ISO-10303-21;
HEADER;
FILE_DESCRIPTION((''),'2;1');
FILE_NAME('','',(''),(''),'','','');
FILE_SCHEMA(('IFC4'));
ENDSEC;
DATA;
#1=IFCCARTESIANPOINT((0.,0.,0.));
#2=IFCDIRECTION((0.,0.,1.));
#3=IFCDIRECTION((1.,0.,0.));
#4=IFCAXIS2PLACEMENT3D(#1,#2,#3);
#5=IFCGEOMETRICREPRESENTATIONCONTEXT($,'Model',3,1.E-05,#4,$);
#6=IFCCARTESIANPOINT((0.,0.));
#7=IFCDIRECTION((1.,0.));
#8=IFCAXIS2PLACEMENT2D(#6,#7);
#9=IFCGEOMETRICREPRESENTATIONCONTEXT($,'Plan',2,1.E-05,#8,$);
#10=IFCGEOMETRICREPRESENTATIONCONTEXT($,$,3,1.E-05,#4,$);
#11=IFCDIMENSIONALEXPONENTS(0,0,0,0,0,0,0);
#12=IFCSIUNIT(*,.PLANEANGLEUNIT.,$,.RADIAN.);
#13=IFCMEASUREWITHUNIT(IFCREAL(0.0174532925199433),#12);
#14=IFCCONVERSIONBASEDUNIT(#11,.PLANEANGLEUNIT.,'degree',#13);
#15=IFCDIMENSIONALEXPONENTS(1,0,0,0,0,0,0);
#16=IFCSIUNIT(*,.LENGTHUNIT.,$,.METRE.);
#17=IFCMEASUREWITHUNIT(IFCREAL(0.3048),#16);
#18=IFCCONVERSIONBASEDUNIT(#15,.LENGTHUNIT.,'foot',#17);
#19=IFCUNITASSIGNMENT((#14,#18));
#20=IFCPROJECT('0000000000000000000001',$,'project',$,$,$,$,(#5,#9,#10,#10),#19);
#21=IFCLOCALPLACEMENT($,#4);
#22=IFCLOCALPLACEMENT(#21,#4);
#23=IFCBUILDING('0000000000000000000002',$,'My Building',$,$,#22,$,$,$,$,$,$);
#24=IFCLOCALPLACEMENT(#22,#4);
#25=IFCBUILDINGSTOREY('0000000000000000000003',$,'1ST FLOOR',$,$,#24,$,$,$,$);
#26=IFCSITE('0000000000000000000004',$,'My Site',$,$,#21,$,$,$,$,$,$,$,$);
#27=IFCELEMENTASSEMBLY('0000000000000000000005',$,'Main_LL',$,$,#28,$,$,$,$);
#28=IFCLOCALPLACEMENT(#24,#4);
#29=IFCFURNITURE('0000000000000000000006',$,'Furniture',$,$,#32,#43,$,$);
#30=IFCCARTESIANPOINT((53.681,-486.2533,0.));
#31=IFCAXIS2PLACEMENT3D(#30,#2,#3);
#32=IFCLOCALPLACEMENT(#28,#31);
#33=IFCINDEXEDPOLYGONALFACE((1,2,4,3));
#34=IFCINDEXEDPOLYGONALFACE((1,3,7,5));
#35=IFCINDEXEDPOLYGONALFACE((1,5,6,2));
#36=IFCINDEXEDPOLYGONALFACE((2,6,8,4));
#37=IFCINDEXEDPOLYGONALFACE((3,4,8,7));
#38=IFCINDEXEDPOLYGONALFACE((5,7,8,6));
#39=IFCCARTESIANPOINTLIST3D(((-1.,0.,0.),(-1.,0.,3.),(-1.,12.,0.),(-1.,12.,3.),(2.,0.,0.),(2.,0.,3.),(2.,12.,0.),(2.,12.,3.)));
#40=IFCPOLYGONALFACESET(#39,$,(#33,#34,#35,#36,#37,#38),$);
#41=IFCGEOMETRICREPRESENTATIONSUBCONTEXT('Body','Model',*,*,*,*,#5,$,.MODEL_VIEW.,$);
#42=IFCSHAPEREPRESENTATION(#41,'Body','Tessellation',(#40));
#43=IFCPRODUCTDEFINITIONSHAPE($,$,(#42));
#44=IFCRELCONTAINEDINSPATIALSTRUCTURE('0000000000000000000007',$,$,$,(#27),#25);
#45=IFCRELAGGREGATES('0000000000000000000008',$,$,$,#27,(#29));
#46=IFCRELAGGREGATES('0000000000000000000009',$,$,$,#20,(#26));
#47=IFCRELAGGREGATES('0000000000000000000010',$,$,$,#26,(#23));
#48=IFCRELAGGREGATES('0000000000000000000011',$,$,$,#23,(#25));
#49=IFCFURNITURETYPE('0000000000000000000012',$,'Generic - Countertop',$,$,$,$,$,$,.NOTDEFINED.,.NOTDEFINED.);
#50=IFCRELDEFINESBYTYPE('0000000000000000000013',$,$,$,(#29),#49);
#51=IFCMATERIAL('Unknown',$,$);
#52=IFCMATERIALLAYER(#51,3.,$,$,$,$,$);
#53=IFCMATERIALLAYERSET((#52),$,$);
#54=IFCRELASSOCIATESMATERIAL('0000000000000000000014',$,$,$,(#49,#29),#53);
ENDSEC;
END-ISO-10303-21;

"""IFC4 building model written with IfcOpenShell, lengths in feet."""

from ifc_helpers import new_model, entity, si_unit, converted_unit, frame, origin_with_axes, origin_2d_with_axis, place, context, subcontext, project, spatial, line, indexed_curve, outline, extrude, material, layer, layer_set, layer_usage, type_object, element, aggregate, save


model = new_model("IFC4")

# Units and contexts
model_context = context("Model", 3, precision=1e-05, world=origin_with_axes())
plan_context = context("Plan", 2, precision=1e-05, world=origin_2d_with_axis())
context_of_model = context(None, 3, precision=1e-05, world=origin_with_axes())
body_context = subcontext(model_context, "Body", "Model", "MODEL_VIEW")
ifc_project = project(units=[converted_unit("PLANEANGLEUNIT", "degree", entity("IfcReal", 0.0174532925199433), si_unit("PLANEANGLEUNIT", "RADIAN"), dimensions=[0, 0, 0, 0, 0, 0, 0]), converted_unit("LENGTHUNIT", "foot", entity("IfcReal", 0.3048), si_unit("LENGTHUNIT", "METRE"), dimensions=[1, 0, 0, 0, 0, 0, 0])], contexts=[model_context, plan_context, context_of_model, context_of_model])

# Site, building, storey
site_placement = place(None, origin_with_axes())
site = spatial("IfcSite", under=ifc_project, at=site_placement, Name="My Site")
building_placement = place(site_placement, origin_with_axes())
building = spatial("IfcBuilding", under=site, at=building_placement, Name="My Building")
storey_placement = place(building_placement, origin_with_axes())
storey = spatial("IfcBuildingStorey", under=building, at=storey_placement, Name="1ST FLOOR")

# Element assembly, furniture
assembly_placement = place(storey_placement, origin_with_axes())
assembly = element("IfcElementAssembly", 1, at=assembly_placement, inside=storey, Name="Main_LL")
ifc_material_1 = material(Name="Unknown")
ifc_layer_1 = layer(ifc_material_1, 3.0)
ifc_layer_set_1 = layer_set([ifc_layer_1])
ifc_layer_usage_1 = layer_usage(ifc_layer_set_1, "AXIS3", "POSITIVE", 0.0)
furniture_type_1 = type_object("IfcFurnitureType", Name="Generic - Countertop", AssemblyPlace="NOTDEFINED", PredefinedType="NOTDEFINED", material=ifc_layer_set_1)
furniture_1_placement = place(assembly_placement, frame((53.681, -486.2533, 0.0), z_axis=(0.0, 0.0, 1.0), x_axis=(1.0, 0.0, 0.0)))
furniture_1 = element("IfcFurniture", 2, at=furniture_1_placement, type_object=furniture_type_1, material=ifc_layer_usage_1, Name="Furniture", context=body_context, shape_type="SweptSolid", body=[
    extrude(outline(indexed_curve([(-1.0, 12.0), (2.0, 12.0), (2.0, 0.0), (-1.0, 0.0)], segments=[line(4, 1), line(1, 2), line(2, 3), line(3, 4)], self_intersect=False)), None, (0.0, 0.0, 1.0), 3.0),
])
aggregate(assembly, [furniture_1])

save(model, "model.ifc")
